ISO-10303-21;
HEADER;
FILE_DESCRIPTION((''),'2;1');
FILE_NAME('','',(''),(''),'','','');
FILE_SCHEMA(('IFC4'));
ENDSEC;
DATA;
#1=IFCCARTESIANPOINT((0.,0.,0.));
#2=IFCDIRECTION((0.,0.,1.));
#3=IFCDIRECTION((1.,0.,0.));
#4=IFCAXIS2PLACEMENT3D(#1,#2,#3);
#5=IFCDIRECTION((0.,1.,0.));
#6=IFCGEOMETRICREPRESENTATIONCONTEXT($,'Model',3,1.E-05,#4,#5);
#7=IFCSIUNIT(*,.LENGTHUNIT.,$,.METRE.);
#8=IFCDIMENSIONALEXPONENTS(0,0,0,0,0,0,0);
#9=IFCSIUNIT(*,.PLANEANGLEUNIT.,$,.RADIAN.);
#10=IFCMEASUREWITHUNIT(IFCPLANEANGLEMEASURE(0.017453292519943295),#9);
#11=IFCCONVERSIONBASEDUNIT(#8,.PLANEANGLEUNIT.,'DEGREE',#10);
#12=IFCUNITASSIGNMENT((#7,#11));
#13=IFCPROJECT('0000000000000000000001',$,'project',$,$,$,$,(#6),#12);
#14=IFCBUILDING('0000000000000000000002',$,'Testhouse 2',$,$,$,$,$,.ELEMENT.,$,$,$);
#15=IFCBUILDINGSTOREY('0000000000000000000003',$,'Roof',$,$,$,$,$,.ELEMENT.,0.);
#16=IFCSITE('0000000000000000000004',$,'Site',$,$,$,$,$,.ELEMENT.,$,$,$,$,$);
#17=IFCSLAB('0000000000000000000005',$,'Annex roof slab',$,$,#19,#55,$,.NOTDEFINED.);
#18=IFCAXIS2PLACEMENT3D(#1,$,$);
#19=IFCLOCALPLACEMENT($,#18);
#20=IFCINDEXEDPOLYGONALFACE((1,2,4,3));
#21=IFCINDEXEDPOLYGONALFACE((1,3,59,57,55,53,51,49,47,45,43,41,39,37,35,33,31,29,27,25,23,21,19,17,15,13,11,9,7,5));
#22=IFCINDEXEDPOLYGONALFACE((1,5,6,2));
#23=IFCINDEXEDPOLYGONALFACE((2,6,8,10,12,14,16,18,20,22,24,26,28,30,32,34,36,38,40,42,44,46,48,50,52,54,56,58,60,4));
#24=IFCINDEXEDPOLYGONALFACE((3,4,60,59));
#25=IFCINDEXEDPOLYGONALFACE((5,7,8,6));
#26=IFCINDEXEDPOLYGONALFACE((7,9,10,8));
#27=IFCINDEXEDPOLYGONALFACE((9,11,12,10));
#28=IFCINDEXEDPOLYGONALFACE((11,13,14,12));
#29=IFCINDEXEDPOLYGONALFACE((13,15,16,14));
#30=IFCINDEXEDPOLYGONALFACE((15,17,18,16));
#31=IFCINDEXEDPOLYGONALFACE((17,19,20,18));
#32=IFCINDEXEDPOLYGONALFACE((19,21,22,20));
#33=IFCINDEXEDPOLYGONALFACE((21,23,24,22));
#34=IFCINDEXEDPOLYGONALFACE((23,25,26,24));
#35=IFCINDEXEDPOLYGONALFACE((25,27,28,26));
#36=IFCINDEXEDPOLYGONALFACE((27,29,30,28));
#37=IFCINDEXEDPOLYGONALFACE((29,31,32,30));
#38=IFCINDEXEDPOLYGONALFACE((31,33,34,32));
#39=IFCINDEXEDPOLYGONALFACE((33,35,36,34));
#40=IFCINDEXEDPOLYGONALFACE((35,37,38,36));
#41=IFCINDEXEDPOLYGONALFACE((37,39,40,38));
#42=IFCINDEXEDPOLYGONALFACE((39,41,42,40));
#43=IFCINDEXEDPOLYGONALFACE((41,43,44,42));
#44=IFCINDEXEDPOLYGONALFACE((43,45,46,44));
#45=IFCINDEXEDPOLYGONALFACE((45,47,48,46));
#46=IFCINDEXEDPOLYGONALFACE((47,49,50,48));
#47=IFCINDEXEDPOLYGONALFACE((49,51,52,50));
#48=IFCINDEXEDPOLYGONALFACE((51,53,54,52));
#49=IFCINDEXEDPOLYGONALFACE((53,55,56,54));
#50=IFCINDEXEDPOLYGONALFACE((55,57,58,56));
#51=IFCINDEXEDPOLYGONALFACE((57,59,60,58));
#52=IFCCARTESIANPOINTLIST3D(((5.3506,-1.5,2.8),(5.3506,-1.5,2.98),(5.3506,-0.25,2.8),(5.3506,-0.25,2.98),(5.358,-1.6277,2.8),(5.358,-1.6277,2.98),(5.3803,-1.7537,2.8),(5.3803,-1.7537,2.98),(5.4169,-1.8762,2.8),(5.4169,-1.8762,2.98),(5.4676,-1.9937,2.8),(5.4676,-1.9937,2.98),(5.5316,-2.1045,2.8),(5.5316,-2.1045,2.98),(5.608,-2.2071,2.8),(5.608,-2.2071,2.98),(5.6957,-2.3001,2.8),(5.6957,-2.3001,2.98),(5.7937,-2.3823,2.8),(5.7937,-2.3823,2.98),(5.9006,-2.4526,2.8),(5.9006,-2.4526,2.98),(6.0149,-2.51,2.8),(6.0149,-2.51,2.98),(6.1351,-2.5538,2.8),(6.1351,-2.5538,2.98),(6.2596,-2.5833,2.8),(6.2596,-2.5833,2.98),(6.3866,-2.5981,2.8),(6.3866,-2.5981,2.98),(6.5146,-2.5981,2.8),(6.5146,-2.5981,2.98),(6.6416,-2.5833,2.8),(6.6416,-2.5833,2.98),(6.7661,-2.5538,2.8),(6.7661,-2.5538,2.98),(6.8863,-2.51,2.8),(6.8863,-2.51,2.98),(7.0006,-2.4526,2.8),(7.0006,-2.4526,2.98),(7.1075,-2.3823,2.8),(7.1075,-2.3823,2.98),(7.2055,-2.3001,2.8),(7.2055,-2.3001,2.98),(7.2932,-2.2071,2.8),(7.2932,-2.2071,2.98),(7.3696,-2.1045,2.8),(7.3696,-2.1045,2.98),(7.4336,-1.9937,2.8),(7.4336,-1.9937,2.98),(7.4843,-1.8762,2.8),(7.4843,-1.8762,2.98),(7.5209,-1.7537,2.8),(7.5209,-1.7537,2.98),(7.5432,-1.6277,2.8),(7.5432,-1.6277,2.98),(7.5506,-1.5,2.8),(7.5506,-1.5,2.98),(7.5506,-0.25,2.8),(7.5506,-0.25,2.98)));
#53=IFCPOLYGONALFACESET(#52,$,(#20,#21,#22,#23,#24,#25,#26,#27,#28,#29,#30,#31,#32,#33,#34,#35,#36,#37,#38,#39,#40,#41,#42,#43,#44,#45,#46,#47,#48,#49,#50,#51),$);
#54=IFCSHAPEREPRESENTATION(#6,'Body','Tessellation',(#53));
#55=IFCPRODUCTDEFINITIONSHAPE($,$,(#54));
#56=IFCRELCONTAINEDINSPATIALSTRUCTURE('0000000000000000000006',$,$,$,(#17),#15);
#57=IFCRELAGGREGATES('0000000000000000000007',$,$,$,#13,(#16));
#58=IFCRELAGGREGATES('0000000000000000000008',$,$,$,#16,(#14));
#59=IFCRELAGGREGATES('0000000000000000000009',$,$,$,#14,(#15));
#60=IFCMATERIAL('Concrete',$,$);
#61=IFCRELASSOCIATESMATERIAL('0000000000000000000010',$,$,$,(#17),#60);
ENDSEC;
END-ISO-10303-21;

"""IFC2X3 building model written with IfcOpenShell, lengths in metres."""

from ifc_helpers import new_model, entity, si_unit, converted_unit, direction, frame, frame_2d, origin_with_axes, place, context, project, spatial, polyline, circle_curve, parameter, trimmed, segment, composite_curve, outline, extrude, material, element, save


model = new_model("IFC2X3")

# Units and contexts
model_context = context("Model", 3, precision=1e-05, world=origin_with_axes(), true_north=direction((0.0, 1.0, 0.0)))
ifc_project = project(units=[si_unit("LENGTHUNIT", "METRE"), converted_unit("PLANEANGLEUNIT", "DEGREE", entity("IfcPlaneAngleMeasure", 0.017453292519943295), si_unit("PLANEANGLEUNIT", "RADIAN"), dimensions=[0, 0, 0, 0, 0, 0, 0])], contexts=[model_context])

# Site, building, storey
site = spatial("IfcSite", under=ifc_project, Name="Site", CompositionType="ELEMENT")
building = spatial("IfcBuilding", under=site, Name="Testhouse 2", CompositionType="ELEMENT")
storey = spatial("IfcBuildingStorey", under=building, Name="Roof", CompositionType="ELEMENT", Elevation=0.0)

# Slab
ifc_material = material(Name="Concrete")
slab_placement = place(None, origin_with_axes())
element("IfcSlab", 1, at=slab_placement, inside=storey, material=ifc_material, Name="Annex roof slab", PredefinedType="NOTDEFINED", context=model_context, shape_type="SweptSolid", body=[
    extrude(outline(composite_curve([segment(polyline([(5.3506, -0.25), (5.3506, -1.5)]), True, "CONTINUOUS"), segment(trimmed(circle_curve(frame_2d((6.4506, -1.5), x_axis=(1.0, 0.0)), 1.1), [parameter(180.0)], [parameter(0.0)], True, "PARAMETER"), True, "CONTINUOUS"), segment(polyline([(7.5506, -1.5), (7.5506, -0.25)]), True, "CONTINUOUS"), segment(polyline([(7.5506, -0.25), (5.3506, -0.25)]), True, "CONTINUOUS")], self_intersect=False)), frame((0.0, 0.0, 2.8), z_axis=(0.0, 0.0, 1.0), x_axis=(1.0, 0.0, 0.0)), (0.0, 0.0, 1.0), 0.18),
])

save(model, "model.ifc")
